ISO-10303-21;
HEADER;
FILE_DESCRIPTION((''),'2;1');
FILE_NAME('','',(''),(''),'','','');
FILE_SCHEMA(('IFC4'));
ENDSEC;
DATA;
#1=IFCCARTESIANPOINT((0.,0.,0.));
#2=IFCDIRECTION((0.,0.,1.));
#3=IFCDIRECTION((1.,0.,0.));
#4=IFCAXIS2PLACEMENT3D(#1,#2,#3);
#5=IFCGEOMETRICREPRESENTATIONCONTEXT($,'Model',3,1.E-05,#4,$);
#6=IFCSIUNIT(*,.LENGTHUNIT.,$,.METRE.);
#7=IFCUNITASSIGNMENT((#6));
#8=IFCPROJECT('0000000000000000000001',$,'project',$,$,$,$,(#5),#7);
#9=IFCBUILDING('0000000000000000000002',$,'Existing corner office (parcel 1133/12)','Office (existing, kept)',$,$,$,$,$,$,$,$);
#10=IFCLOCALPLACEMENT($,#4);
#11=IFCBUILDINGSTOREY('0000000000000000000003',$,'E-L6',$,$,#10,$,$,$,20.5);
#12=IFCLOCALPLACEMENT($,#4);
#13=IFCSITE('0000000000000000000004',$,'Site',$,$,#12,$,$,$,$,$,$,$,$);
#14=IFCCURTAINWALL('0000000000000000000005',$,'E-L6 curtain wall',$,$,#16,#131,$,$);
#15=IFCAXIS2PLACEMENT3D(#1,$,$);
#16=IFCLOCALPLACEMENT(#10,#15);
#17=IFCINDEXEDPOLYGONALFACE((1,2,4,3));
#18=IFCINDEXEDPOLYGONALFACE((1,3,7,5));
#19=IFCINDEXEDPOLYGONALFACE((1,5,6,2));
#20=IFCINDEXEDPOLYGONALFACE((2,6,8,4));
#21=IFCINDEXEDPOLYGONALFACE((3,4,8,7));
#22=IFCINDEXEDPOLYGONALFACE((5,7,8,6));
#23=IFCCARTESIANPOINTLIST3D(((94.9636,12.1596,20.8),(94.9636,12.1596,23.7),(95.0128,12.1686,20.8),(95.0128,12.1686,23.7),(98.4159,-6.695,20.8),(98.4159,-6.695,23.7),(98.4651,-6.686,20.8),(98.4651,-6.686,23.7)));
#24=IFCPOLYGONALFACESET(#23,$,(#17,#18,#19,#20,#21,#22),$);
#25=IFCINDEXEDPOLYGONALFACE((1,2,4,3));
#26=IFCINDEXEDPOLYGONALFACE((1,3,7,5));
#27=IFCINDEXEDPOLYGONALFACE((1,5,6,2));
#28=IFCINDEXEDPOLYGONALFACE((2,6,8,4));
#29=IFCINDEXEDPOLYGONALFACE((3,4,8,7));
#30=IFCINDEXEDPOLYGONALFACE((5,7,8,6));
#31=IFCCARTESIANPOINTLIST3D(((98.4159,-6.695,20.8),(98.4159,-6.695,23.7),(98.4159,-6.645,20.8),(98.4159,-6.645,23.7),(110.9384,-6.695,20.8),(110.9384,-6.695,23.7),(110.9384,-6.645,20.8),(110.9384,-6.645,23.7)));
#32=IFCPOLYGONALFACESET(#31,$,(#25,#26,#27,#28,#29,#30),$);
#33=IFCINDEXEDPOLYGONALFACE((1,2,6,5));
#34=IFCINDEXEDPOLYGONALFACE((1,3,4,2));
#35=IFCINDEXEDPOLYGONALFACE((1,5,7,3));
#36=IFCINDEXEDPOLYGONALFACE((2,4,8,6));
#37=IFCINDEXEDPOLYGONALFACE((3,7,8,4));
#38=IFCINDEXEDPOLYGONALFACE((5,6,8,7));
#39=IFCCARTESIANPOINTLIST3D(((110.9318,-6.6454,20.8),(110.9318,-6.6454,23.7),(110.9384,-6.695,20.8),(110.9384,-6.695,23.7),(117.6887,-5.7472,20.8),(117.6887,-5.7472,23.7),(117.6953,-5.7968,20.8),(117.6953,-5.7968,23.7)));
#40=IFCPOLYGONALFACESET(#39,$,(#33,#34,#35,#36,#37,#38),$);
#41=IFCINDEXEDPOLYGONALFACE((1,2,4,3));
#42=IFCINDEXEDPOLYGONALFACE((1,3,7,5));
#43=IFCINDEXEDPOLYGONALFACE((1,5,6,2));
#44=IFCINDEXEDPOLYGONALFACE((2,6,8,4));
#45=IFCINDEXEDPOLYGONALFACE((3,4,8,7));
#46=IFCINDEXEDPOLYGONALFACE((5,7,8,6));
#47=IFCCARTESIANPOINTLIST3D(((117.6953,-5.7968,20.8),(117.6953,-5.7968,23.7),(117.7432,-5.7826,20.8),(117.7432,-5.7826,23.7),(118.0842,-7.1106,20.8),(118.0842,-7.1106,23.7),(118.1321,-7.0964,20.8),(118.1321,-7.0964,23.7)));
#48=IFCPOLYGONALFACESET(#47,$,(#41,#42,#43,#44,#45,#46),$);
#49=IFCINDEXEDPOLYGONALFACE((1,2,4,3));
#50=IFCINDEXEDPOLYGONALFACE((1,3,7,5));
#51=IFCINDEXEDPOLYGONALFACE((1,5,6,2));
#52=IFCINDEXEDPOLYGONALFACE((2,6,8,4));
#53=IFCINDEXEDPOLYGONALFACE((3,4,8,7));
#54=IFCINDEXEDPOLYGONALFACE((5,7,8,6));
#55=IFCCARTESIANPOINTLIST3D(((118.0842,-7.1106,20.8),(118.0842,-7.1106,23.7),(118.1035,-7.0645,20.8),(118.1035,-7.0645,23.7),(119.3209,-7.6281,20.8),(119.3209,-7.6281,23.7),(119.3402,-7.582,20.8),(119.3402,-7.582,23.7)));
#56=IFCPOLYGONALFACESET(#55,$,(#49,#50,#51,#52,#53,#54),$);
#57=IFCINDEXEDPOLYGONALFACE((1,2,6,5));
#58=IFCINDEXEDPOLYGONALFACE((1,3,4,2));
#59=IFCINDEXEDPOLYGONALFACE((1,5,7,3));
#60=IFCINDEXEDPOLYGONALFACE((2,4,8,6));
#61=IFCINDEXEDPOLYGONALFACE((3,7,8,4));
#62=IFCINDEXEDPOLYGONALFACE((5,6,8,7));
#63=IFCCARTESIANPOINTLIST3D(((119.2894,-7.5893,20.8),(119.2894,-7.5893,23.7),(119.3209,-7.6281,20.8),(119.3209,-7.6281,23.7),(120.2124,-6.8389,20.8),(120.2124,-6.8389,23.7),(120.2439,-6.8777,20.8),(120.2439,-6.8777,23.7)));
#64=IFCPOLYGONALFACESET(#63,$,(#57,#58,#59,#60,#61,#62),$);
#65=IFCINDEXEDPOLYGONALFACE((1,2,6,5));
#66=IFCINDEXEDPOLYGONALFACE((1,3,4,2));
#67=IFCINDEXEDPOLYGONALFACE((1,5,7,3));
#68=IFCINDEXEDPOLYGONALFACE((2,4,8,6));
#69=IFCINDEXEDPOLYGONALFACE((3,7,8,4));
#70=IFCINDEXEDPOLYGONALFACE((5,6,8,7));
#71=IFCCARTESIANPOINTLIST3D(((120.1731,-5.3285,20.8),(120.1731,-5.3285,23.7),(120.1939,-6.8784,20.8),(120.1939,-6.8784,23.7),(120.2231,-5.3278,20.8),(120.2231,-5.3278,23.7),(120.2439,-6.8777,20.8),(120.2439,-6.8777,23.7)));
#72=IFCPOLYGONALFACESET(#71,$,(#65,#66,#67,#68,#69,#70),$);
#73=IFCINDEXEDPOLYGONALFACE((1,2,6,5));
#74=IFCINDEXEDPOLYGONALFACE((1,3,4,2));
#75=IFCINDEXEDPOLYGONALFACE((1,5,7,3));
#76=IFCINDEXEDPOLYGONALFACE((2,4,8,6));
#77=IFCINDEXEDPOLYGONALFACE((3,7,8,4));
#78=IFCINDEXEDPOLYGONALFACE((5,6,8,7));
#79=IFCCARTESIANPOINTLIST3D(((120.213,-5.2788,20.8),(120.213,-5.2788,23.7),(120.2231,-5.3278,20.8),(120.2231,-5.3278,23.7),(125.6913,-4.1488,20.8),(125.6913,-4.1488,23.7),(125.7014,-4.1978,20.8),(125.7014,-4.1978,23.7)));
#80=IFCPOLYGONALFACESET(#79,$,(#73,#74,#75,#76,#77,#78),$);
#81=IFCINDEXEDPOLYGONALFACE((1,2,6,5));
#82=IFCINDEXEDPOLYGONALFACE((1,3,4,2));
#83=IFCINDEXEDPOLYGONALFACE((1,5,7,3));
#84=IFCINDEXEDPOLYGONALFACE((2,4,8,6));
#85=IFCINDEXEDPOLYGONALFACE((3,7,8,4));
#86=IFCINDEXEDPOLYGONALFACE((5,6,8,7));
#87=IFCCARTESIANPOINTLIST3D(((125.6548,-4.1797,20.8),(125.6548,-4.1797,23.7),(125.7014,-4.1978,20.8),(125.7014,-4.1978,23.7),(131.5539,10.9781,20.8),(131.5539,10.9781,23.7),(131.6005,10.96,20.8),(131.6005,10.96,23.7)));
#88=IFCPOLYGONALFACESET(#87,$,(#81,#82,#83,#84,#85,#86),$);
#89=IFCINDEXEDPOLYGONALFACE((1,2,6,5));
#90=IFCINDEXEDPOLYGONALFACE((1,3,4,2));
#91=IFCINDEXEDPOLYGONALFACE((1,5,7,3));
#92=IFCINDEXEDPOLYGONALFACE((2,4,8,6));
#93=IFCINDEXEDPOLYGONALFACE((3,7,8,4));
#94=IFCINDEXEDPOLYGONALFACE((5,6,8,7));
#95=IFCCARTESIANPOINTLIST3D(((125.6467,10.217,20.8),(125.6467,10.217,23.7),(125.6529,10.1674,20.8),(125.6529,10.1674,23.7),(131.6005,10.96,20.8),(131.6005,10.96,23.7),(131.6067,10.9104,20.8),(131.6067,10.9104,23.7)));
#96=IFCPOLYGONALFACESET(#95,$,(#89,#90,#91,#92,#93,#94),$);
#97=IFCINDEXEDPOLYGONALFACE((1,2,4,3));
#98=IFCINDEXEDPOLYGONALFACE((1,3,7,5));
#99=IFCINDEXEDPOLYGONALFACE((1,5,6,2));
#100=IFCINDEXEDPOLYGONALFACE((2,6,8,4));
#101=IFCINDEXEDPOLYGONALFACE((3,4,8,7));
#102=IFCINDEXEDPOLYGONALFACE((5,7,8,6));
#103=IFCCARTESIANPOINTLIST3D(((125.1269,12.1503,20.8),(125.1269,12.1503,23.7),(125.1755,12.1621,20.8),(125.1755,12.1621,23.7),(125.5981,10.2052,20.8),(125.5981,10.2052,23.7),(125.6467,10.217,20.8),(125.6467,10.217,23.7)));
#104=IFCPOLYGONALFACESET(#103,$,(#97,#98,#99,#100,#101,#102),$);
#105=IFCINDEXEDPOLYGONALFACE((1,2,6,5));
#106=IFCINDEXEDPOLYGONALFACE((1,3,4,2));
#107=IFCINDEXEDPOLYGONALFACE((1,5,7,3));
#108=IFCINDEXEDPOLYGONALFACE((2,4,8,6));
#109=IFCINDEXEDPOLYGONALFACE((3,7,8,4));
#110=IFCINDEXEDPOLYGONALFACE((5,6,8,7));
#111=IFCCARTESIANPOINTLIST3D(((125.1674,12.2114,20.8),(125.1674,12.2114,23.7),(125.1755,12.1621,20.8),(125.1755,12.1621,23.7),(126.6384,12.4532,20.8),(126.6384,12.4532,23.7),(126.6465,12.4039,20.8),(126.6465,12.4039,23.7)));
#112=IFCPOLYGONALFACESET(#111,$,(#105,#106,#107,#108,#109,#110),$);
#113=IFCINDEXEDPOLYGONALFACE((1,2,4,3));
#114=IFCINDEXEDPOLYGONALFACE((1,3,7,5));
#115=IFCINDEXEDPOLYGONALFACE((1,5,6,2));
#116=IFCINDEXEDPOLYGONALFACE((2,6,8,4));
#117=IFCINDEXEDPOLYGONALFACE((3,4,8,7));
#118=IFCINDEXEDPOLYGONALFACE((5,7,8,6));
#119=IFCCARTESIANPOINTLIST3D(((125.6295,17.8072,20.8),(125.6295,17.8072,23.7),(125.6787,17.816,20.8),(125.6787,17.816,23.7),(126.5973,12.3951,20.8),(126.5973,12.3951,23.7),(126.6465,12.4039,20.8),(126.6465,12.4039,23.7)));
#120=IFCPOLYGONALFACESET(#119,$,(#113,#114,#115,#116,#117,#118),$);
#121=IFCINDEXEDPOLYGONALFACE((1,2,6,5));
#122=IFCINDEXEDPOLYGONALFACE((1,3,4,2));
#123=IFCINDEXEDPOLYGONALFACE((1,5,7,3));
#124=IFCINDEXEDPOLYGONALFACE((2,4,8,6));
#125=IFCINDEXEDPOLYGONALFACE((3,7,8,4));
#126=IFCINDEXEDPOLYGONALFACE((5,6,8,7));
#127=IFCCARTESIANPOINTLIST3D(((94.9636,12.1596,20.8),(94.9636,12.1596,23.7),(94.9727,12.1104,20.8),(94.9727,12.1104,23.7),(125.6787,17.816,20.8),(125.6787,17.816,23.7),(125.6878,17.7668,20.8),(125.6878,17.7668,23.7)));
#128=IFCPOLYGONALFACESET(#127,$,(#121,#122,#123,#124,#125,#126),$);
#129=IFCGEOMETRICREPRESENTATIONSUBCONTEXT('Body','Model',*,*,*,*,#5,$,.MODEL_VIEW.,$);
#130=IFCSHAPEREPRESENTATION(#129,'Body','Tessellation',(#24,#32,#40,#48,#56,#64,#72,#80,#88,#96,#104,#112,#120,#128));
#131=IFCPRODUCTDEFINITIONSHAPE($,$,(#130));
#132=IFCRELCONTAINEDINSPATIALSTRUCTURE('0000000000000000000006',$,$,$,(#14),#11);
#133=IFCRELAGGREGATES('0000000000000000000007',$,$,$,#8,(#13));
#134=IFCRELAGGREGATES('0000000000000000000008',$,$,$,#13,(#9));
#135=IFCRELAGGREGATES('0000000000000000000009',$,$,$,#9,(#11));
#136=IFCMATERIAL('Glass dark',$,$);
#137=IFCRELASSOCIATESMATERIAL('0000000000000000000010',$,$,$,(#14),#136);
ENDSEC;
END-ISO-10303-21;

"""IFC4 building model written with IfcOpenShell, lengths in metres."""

from ifc_helpers import new_model, si_unit, frame, origin_with_axes, place, context, subcontext, project, spatial, polyline, outline, extrude, material, element, save


model = new_model("IFC4")

# Units and contexts
model_context = context("Model", 3, precision=1e-05, world=origin_with_axes())
body_context = subcontext(model_context, "Body", "Model", "MODEL_VIEW")
ifc_project = project(units=[si_unit("LENGTHUNIT", "METRE")], contexts=[model_context])

# Site, building, storey
site_placement = place(None, origin_with_axes())
site = spatial("IfcSite", under=ifc_project, at=site_placement, Name="Site")
building = spatial("IfcBuilding", under=site, Name="Existing corner office (parcel 1133/12)", Description="Office (existing, kept)")
storey_placement = place(None, origin_with_axes())
storey = spatial("IfcBuildingStorey", under=building, at=storey_placement, Name="E-L6", Elevation=20.5)

# Curtain wall
ifc_material_1 = material(Name="Glass dark")
curtain_wall_placement = place(storey_placement, origin_with_axes())
element("IfcCurtainWall", 1, at=curtain_wall_placement, inside=storey, material=ifc_material_1, Name="E-L6 curtain wall", context=body_context, shape_type="SweptSolid", body=[
    extrude(outline(polyline([(94.9636, 12.1596), (98.4159, -6.695), (98.4651, -6.686), (95.0128, 12.1686), (94.9636, 12.1596)])), frame((0.0, 0.0, 20.8), z_axis=(0.0, 0.0, 1.0), x_axis=(1.0, 0.0, 0.0)), (0.0, 0.0, 1.0), 2.9),
    extrude(outline(polyline([(98.4159, -6.695), (110.9384, -6.695), (110.9384, -6.645), (98.4159, -6.645), (98.4159, -6.695)])), frame((0.0, 0.0, 20.8), z_axis=(0.0, 0.0, 1.0), x_axis=(1.0, 0.0, 0.0)), (0.0, 0.0, 1.0), 2.9),
    extrude(outline(polyline([(110.9384, -6.695), (117.6953, -5.7968), (117.6887, -5.7472), (110.9318, -6.6454), (110.9384, -6.695)])), frame((0.0, 0.0, 20.8), z_axis=(0.0, 0.0, 1.0), x_axis=(1.0, 0.0, 0.0)), (0.0, 0.0, 1.0), 2.9),
    extrude(outline(polyline([(117.6953, -5.7968), (118.0842, -7.1106), (118.1321, -7.0964), (117.7432, -5.7826), (117.6953, -5.7968)])), frame((0.0, 0.0, 20.8), z_axis=(0.0, 0.0, 1.0), x_axis=(1.0, 0.0, 0.0)), (0.0, 0.0, 1.0), 2.9),
    extrude(outline(polyline([(118.0842, -7.1106), (119.3209, -7.6281), (119.3402, -7.582), (118.1035, -7.0645), (118.0842, -7.1106)])), frame((0.0, 0.0, 20.8), z_axis=(0.0, 0.0, 1.0), x_axis=(1.0, 0.0, 0.0)), (0.0, 0.0, 1.0), 2.9),
    extrude(outline(polyline([(119.3209, -7.6281), (120.2439, -6.8777), (120.2124, -6.8389), (119.2894, -7.5893), (119.3209, -7.6281)])), frame((0.0, 0.0, 20.8), z_axis=(0.0, 0.0, 1.0), x_axis=(1.0, 0.0, 0.0)), (0.0, 0.0, 1.0), 2.9),
    extrude(outline(polyline([(120.2439, -6.8777), (120.2231, -5.3278), (120.1731, -5.3285), (120.1939, -6.8784), (120.2439, -6.8777)])), frame((0.0, 0.0, 20.8), z_axis=(0.0, 0.0, 1.0), x_axis=(1.0, 0.0, 0.0)), (0.0, 0.0, 1.0), 2.9),
    extrude(outline(polyline([(120.2231, -5.3278), (125.7014, -4.1978), (125.6913, -4.1488), (120.213, -5.2788), (120.2231, -5.3278)])), frame((0.0, 0.0, 20.8), z_axis=(0.0, 0.0, 1.0), x_axis=(1.0, 0.0, 0.0)), (0.0, 0.0, 1.0), 2.9),
    extrude(outline(polyline([(125.7014, -4.1978), (131.6005, 10.96), (131.5539, 10.9781), (125.6548, -4.1797), (125.7014, -4.1978)])), frame((0.0, 0.0, 20.8), z_axis=(0.0, 0.0, 1.0), x_axis=(1.0, 0.0, 0.0)), (0.0, 0.0, 1.0), 2.9),
    extrude(outline(polyline([(131.6005, 10.96), (125.6467, 10.217), (125.6529, 10.1674), (131.6067, 10.9104), (131.6005, 10.96)])), frame((0.0, 0.0, 20.8), z_axis=(0.0, 0.0, 1.0), x_axis=(1.0, 0.0, 0.0)), (0.0, 0.0, 1.0), 2.9),
    extrude(outline(polyline([(125.6467, 10.217), (125.1755, 12.1621), (125.1269, 12.1503), (125.5981, 10.2052), (125.6467, 10.217)])), frame((0.0, 0.0, 20.8), z_axis=(0.0, 0.0, 1.0), x_axis=(1.0, 0.0, 0.0)), (0.0, 0.0, 1.0), 2.9),
    extrude(outline(polyline([(125.1755, 12.1621), (126.6465, 12.4039), (126.6384, 12.4532), (125.1674, 12.2114), (125.1755, 12.1621)])), frame((0.0, 0.0, 20.8), z_axis=(0.0, 0.0, 1.0), x_axis=(1.0, 0.0, 0.0)), (0.0, 0.0, 1.0), 2.9),
    extrude(outline(polyline([(126.6465, 12.4039), (125.6787, 17.816), (125.6295, 17.8072), (126.5973, 12.3951), (126.6465, 12.4039)])), frame((0.0, 0.0, 20.8), z_axis=(0.0, 0.0, 1.0), x_axis=(1.0, 0.0, 0.0)), (0.0, 0.0, 1.0), 2.9),
    extrude(outline(polyline([(125.6787, 17.816), (94.9636, 12.1596), (94.9727, 12.1104), (125.6878, 17.7668), (125.6787, 17.816)])), frame((0.0, 0.0, 20.8), z_axis=(0.0, 0.0, 1.0), x_axis=(1.0, 0.0, 0.0)), (0.0, 0.0, 1.0), 2.9),
])

save(model, "model.ifc")
